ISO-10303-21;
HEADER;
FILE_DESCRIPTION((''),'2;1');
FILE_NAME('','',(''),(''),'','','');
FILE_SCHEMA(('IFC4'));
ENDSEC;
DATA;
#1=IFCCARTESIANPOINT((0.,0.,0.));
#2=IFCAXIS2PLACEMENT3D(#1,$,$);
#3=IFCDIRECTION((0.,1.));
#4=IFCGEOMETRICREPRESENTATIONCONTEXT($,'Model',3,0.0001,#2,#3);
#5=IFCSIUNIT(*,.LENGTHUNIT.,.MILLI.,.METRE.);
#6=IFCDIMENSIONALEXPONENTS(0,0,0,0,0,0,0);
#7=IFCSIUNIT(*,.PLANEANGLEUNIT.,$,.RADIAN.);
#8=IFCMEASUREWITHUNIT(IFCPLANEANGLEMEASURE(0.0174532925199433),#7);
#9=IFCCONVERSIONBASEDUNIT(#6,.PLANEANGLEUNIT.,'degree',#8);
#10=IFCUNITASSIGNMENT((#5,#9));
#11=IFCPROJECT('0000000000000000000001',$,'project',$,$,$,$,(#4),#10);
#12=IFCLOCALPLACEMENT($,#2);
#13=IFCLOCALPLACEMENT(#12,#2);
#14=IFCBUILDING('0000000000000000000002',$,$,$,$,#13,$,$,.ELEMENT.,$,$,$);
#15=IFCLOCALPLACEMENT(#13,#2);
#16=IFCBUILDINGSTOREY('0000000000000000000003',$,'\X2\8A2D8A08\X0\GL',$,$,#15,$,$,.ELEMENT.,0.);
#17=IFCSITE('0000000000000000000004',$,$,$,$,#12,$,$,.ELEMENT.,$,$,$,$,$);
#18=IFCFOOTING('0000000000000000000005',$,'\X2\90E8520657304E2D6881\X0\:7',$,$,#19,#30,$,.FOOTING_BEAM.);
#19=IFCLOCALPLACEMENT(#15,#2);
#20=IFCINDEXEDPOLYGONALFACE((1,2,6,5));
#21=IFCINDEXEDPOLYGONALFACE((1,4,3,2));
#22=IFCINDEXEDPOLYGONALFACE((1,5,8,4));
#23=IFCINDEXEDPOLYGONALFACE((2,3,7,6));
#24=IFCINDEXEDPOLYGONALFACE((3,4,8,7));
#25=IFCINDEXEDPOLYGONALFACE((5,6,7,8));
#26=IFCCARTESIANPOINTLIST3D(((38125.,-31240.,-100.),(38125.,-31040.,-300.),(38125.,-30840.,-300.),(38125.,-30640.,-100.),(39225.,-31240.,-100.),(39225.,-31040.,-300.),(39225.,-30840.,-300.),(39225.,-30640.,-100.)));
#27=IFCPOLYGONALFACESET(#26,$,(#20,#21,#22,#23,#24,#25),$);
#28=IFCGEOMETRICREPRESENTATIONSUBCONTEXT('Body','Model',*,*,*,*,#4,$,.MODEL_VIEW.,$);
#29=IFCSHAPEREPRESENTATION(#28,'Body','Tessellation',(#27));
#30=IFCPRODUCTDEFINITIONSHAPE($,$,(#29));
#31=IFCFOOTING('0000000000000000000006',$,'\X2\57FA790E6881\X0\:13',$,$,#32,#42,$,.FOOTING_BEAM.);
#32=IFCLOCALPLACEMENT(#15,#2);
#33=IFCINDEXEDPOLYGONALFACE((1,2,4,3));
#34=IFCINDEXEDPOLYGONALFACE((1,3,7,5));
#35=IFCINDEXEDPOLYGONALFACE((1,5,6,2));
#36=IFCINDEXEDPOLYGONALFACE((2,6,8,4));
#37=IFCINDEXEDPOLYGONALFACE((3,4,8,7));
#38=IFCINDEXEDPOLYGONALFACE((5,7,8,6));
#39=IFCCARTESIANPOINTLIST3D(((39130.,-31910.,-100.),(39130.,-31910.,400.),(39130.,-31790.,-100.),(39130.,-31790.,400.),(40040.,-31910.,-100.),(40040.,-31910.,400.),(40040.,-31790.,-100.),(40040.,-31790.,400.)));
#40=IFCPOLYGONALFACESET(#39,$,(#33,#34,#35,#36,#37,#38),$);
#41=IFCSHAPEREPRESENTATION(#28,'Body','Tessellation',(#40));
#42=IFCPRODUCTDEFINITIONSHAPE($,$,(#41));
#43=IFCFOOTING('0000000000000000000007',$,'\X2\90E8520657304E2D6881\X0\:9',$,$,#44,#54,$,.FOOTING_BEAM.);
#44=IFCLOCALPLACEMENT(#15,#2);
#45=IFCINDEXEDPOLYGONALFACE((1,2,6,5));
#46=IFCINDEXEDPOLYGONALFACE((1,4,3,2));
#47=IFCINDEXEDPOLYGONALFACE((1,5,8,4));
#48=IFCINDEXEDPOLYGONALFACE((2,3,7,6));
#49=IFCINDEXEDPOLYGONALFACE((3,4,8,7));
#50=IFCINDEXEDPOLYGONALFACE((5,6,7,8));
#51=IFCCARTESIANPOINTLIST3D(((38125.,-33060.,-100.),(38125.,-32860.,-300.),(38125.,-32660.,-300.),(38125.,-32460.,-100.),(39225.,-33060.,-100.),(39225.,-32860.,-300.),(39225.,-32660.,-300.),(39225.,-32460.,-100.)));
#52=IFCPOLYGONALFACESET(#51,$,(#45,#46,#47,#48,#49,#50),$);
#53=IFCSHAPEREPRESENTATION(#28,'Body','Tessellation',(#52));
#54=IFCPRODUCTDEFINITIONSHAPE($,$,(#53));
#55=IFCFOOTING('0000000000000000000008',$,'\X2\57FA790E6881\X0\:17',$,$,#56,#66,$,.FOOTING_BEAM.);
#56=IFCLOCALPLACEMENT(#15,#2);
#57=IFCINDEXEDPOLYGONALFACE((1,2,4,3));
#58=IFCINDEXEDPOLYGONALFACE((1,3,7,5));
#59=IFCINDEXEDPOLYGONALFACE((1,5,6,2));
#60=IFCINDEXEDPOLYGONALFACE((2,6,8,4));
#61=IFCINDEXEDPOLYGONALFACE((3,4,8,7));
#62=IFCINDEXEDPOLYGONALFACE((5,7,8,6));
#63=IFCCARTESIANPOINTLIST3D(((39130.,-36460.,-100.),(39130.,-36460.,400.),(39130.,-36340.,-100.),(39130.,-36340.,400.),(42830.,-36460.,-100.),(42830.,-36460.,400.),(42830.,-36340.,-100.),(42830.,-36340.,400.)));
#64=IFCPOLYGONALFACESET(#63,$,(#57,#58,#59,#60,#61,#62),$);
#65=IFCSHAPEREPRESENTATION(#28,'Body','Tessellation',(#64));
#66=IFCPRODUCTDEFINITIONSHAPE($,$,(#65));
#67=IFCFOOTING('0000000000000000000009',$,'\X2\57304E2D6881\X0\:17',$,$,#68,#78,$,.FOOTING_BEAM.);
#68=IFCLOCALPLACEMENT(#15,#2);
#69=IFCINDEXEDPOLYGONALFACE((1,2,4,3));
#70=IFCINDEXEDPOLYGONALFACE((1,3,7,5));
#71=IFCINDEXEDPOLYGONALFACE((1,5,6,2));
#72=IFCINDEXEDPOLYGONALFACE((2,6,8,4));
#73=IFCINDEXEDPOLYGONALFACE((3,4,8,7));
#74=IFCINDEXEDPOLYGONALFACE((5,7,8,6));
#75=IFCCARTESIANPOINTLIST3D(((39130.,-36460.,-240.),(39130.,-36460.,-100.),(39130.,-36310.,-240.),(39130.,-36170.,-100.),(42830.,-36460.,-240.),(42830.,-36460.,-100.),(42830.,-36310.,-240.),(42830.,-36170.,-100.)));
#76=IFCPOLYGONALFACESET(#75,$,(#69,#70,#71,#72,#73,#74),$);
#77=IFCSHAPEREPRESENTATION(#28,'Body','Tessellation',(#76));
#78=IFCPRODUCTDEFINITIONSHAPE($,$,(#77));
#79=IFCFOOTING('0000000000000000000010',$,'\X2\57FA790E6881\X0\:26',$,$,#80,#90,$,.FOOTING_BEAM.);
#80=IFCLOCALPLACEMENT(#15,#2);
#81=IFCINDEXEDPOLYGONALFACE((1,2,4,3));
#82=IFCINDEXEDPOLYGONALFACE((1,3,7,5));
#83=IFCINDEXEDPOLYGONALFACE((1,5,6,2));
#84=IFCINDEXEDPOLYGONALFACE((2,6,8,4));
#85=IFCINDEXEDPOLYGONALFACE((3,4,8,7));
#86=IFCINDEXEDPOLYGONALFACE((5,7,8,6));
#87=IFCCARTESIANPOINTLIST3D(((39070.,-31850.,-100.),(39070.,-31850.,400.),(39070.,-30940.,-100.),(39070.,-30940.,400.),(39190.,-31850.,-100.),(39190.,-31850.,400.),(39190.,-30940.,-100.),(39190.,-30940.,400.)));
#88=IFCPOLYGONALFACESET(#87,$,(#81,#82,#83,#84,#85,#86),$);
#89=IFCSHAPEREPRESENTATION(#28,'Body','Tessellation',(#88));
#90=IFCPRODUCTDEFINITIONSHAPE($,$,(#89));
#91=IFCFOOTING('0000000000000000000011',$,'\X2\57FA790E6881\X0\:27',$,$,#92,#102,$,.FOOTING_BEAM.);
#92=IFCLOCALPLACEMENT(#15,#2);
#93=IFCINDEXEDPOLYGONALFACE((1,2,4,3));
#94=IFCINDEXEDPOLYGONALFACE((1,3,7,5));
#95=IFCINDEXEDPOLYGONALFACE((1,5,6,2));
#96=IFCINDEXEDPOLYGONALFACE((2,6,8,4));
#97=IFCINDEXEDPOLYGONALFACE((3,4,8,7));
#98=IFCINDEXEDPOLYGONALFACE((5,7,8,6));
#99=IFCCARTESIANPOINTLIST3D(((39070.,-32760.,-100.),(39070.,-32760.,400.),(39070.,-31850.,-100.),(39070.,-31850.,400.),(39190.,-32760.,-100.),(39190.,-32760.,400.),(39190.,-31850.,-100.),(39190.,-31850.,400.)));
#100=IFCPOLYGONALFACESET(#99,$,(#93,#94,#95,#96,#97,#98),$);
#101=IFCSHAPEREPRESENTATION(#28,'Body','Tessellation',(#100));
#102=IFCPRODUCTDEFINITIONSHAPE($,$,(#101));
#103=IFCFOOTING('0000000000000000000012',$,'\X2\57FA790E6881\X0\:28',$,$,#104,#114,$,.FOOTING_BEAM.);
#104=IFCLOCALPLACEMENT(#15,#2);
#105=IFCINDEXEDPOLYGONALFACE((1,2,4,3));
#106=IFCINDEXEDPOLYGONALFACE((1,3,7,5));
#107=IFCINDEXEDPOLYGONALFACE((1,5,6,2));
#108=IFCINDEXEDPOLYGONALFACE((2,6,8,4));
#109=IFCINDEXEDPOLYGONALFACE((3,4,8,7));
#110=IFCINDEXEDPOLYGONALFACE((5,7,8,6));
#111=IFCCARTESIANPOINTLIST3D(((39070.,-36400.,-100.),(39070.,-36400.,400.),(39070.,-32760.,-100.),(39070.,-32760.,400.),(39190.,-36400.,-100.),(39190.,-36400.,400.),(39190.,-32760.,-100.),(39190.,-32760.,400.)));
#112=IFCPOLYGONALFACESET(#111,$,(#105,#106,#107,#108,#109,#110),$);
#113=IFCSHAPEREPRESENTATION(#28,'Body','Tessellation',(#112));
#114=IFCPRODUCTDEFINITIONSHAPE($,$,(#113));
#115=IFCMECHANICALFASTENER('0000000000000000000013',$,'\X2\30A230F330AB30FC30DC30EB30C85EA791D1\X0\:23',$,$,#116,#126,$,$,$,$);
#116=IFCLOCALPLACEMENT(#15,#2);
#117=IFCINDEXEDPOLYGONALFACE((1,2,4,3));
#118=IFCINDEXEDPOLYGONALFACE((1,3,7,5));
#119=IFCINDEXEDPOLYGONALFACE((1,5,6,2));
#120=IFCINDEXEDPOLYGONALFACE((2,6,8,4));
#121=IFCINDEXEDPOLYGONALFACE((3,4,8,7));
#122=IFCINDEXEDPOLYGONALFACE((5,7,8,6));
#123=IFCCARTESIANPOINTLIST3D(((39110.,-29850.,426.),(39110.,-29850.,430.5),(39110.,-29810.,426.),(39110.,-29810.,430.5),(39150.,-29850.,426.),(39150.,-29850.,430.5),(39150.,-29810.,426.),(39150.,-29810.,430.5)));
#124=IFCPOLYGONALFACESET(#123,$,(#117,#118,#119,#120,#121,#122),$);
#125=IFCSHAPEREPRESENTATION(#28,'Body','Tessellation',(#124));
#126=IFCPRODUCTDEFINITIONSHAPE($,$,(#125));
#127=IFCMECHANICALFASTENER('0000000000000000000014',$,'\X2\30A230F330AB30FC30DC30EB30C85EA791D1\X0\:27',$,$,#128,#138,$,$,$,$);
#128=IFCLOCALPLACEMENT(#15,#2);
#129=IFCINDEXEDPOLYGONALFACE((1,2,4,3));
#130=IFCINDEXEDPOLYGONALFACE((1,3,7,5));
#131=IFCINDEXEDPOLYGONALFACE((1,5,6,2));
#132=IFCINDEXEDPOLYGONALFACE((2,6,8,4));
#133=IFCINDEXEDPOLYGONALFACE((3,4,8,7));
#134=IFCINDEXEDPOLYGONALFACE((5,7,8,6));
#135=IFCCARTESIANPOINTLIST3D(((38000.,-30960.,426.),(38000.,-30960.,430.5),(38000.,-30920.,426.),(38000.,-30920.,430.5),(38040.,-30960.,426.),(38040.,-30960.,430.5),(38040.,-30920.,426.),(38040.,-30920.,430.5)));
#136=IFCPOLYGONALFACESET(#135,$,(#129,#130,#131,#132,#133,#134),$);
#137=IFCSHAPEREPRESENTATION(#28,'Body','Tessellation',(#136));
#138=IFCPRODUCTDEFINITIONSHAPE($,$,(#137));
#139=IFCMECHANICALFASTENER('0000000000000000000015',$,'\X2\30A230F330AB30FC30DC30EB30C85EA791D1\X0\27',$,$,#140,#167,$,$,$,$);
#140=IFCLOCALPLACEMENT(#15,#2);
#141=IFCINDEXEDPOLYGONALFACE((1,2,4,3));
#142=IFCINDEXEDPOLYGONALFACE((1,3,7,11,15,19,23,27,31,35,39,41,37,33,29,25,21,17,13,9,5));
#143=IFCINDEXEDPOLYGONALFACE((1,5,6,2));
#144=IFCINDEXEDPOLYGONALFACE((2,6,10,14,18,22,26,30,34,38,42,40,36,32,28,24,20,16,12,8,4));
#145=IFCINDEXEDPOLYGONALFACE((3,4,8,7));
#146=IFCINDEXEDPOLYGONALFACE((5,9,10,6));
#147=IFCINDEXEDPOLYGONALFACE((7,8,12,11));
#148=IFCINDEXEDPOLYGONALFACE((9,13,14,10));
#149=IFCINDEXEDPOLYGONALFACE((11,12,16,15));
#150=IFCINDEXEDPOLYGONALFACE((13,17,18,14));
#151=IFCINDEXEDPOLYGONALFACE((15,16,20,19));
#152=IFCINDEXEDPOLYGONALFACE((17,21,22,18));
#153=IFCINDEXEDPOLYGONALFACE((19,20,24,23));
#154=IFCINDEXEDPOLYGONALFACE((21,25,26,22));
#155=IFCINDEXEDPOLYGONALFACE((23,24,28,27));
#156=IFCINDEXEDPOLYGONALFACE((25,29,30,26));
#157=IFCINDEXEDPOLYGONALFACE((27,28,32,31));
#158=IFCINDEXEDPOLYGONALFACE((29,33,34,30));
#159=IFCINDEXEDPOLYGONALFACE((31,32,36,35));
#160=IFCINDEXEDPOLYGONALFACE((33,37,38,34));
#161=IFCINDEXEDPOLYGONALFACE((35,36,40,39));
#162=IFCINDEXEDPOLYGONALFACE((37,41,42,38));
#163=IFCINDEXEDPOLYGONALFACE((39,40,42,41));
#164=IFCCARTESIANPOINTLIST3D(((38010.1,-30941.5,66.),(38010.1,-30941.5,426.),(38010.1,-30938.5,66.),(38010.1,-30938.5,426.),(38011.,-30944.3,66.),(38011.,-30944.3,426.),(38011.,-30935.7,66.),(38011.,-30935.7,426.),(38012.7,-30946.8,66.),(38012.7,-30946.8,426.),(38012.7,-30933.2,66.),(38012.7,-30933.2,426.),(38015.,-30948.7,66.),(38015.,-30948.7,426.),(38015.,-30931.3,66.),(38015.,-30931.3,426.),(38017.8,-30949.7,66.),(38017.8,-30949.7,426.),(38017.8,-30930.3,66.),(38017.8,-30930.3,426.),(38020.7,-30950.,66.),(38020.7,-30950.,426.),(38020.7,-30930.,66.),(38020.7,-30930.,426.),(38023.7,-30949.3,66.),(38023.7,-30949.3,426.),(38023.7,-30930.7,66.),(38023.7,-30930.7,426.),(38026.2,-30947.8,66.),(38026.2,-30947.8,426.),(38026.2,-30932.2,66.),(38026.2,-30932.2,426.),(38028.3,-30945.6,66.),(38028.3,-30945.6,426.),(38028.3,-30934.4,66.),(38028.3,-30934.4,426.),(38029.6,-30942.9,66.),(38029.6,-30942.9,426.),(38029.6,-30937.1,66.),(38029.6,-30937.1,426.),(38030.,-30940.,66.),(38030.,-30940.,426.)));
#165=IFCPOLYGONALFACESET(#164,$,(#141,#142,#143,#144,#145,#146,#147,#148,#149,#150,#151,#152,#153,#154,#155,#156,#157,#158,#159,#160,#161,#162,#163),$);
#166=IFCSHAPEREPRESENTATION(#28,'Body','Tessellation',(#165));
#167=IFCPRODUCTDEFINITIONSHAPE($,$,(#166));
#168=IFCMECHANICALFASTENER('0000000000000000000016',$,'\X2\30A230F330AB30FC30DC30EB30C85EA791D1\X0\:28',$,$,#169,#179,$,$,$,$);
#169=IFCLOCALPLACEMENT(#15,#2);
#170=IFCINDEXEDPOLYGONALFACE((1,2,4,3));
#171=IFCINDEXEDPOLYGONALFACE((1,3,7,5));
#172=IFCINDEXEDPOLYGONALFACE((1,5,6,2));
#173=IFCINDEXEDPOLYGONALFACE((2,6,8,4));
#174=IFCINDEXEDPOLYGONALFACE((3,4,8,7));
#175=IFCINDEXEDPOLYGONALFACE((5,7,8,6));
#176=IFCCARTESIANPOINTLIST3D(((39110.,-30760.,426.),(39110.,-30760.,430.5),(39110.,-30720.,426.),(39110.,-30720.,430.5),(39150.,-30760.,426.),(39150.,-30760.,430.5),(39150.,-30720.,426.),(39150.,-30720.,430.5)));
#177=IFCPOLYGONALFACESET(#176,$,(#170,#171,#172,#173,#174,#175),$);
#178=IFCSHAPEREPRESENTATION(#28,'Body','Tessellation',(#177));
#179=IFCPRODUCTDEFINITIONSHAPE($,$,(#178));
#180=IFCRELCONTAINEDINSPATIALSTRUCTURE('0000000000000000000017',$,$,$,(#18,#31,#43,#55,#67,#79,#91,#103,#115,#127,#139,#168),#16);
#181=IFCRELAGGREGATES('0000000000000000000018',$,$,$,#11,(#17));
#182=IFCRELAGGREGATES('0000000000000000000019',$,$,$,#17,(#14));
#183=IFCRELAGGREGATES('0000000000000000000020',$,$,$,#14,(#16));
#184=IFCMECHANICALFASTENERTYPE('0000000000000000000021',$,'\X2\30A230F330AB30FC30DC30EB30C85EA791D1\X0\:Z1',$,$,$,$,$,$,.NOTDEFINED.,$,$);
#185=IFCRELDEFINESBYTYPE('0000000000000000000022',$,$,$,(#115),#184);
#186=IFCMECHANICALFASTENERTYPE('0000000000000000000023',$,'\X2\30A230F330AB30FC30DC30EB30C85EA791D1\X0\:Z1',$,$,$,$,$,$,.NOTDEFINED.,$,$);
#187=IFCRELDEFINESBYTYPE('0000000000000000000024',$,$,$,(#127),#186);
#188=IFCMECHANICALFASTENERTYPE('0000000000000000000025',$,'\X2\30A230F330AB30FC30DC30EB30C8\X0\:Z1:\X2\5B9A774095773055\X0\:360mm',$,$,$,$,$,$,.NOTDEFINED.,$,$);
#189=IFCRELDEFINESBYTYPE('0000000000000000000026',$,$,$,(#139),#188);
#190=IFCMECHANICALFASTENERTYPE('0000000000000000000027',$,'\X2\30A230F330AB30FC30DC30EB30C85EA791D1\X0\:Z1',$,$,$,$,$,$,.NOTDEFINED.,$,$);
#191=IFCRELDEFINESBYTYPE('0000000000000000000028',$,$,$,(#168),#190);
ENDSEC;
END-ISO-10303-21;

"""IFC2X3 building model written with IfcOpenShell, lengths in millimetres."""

from ifc_helpers import new_model, entity, si_unit, converted_unit, direction, frame, origin, origin_with_axes, origin_2d, place, context, subcontext, project, spatial, polyline, rectangle, circle, outline, extrude, type_object, element, save


model = new_model("IFC2X3")

# Units and contexts
model_context = context("Model", 3, precision=0.0001, world=origin(), true_north=direction((0.0, 1.0)))
body_context = subcontext(model_context, "Body", "Model", "MODEL_VIEW")
ifc_project = project(units=[si_unit("LENGTHUNIT", "METRE", prefix="MILLI"), converted_unit("PLANEANGLEUNIT", "degree", entity("IfcPlaneAngleMeasure", 0.0174532925199433), si_unit("PLANEANGLEUNIT", "RADIAN"), dimensions=[0, 0, 0, 0, 0, 0, 0])], contexts=[model_context])

# Site, building, storey
site_placement = place(None, origin())
site = spatial("IfcSite", under=ifc_project, at=site_placement, CompositionType="ELEMENT")
building_placement = place(site_placement, origin())
building = spatial("IfcBuilding", under=site, at=building_placement, CompositionType="ELEMENT")
storey_placement = place(building_placement, origin())
storey = spatial("IfcBuildingStorey", under=building, at=storey_placement, Name="設計GL", CompositionType="ELEMENT", Elevation=0.0)

# Footings
footing_1_placement = place(storey_placement, frame((38125.0, -30940.0, -300.0), z_axis=(1.0, 0.0, 0.0), x_axis=(0.0, 1.0, 0.0)))
element("IfcFooting", 1, at=footing_1_placement, inside=storey, Name="部分地中梁:7", PredefinedType="FOOTING_BEAM", context=body_context, shape_type="SweptSolid", body=[
    extrude(outline(polyline([(-100.0, 0.0, 0.0), (100.0, 0.0, 0.0), (300.0, 200.0, 0.0), (-300.0, 200.0, 0.0), (-100.0, 0.0, 0.0)])), origin_with_axes(), (0.0, 0.0, 1.0), 1100.0),
])
footing_2_placement = place(storey_placement, frame((39130.0, -31850.0, 150.0), z_axis=(1.0, 0.0, 0.0), x_axis=(0.0, 1.0, 0.0)))
element("IfcFooting", 2, at=footing_2_placement, inside=storey, Name="基礎梁:13", PredefinedType="FOOTING_BEAM", context=body_context, shape_type="SolidModel", body=[
    extrude(rectangle(XDim=120.0, YDim=500.0, at=origin_2d()), origin_with_axes(), (0.0, 0.0, 1.0), 910.0),
])
footing_3_placement = place(storey_placement, frame((38125.0, -32760.0, -300.0), z_axis=(1.0, 0.0, 0.0), x_axis=(0.0, 1.0, 0.0)))
element("IfcFooting", 3, at=footing_3_placement, inside=storey, Name="部分地中梁:9", PredefinedType="FOOTING_BEAM", context=body_context, shape_type="SweptSolid", body=[
    extrude(outline(polyline([(-100.0, 0.0, 0.0), (100.0, 0.0, 0.0), (300.0, 200.0, 0.0), (-300.0, 200.0, 0.0), (-100.0, 0.0, 0.0)])), origin_with_axes(), (0.0, 0.0, 1.0), 1100.0),
])
footing_4_placement = place(storey_placement, frame((39130.0, -36400.0, 150.0), z_axis=(1.0, 0.0, 0.0), x_axis=(0.0, 1.0, 0.0)))
element("IfcFooting", 4, at=footing_4_placement, inside=storey, Name="基礎梁:17", PredefinedType="FOOTING_BEAM", context=body_context, shape_type="SolidModel", body=[
    extrude(rectangle(XDim=120.0, YDim=500.0, at=origin_2d()), origin_with_axes(), (0.0, 0.0, 1.0), 3700.0),
])
footing_5_placement = place(storey_placement, frame((39130.0, -36460.0, -240.0), z_axis=(1.0, 0.0, 0.0), x_axis=(0.0, 1.0, 0.0)))
element("IfcFooting", 5, at=footing_5_placement, inside=storey, Name="地中梁:17", PredefinedType="FOOTING_BEAM", context=body_context, shape_type="SweptSolid", body=[
    extrude(outline(polyline([(0.0, 0.0, 0.0), (150.0, 0.0, 0.0), (290.0, 140.0, 0.0), (0.0, 140.0, 0.0), (0.0, 0.0, 0.0)])), origin_with_axes(), (0.0, 0.0, 1.0), 3700.0),
])
for number, where, z_axis, x_axis, name in (
    (6, (39130.0, -30940.0, 150.0), (0.0, -1.0, 0.0), (1.0, 0.0, 0.0), "基礎梁:26"),
    (7, (39130.0, -31850.0, 150.0), (0.0, -1.0, 0.0), (1.0, 0.0, 0.0), "基礎梁:27"),
):
    element("IfcFooting", number, at=place(storey_placement, frame(where, z_axis=z_axis, x_axis=x_axis)), inside=storey, Name=name, PredefinedType="FOOTING_BEAM", context=body_context, shape_type="SolidModel", body=[
        extrude(rectangle(XDim=120.0, YDim=500.0, at=origin_2d()), origin_with_axes(), (0.0, 0.0, 1.0), 910.0),
    ])
footing_6_placement = place(storey_placement, frame((39130.0, -32760.0, 150.0), z_axis=(0.0, -1.0, 0.0), x_axis=(1.0, 0.0, 0.0)))
element("IfcFooting", 8, at=footing_6_placement, inside=storey, Name="基礎梁:28", PredefinedType="FOOTING_BEAM", context=body_context, shape_type="SolidModel", body=[
    extrude(rectangle(XDim=120.0, YDim=500.0, at=origin_2d()), origin_with_axes(), (0.0, 0.0, 1.0), 3640.0),
])

# Mechanical fasteners
mechanical_fastener_type_1 = type_object("IfcMechanicalFastenerType", Name="アンカーボルト座金:Z1")
mechanical_fastener_1_placement = place(storey_placement, frame((39130.0, -29830.0, 426.0)))
element("IfcMechanicalFastener", 9, at=mechanical_fastener_1_placement, inside=storey, type_object=mechanical_fastener_type_1, Name="アンカーボルト座金:23", context=body_context, shape_type="SweptSolid", body=[
    extrude(rectangle(XDim=40.0, YDim=40.0, at=origin_2d()), origin_with_axes(), (0.0, 0.0, 1.0), 4.5),
])
mechanical_fastener_type_2 = type_object("IfcMechanicalFastenerType", Name="アンカーボルト座金:Z1")
mechanical_fastener_2_placement = place(storey_placement, frame((38020.0, -30940.0, 426.0)))
element("IfcMechanicalFastener", 10, at=mechanical_fastener_2_placement, inside=storey, type_object=mechanical_fastener_type_2, Name="アンカーボルト座金:27", context=body_context, shape_type="SweptSolid", body=[
    extrude(rectangle(XDim=40.0, YDim=40.0, at=origin_2d()), origin_with_axes(), (0.0, 0.0, 1.0), 4.5),
])
mechanical_fastener_type_3 = type_object("IfcMechanicalFastenerType", Name="アンカーボルト:Z1:定着長さ:360mm")
mechanical_fastener_3_placement = place(storey_placement, frame((38020.0, -30940.0, 66.0)))
element("IfcMechanicalFastener", 11, at=mechanical_fastener_3_placement, inside=storey, type_object=mechanical_fastener_type_3, Name="アンカーボルト座金27", context=body_context, shape_type="SweptSolid", body=[
    extrude(circle(Radius=10.0, at=origin_2d()), origin_with_axes(), (0.0, 0.0, 1.0), 360.0),
])
mechanical_fastener_type_4 = type_object("IfcMechanicalFastenerType", Name="アンカーボルト座金:Z1")
mechanical_fastener_4_placement = place(storey_placement, frame((39130.0, -30740.0, 426.0)))
element("IfcMechanicalFastener", 12, at=mechanical_fastener_4_placement, inside=storey, type_object=mechanical_fastener_type_4, Name="アンカーボルト座金:28", context=body_context, shape_type="SweptSolid", body=[
    extrude(rectangle(XDim=40.0, YDim=40.0, at=origin_2d()), origin_with_axes(), (0.0, 0.0, 1.0), 4.5),
])

save(model, "model.ifc")
